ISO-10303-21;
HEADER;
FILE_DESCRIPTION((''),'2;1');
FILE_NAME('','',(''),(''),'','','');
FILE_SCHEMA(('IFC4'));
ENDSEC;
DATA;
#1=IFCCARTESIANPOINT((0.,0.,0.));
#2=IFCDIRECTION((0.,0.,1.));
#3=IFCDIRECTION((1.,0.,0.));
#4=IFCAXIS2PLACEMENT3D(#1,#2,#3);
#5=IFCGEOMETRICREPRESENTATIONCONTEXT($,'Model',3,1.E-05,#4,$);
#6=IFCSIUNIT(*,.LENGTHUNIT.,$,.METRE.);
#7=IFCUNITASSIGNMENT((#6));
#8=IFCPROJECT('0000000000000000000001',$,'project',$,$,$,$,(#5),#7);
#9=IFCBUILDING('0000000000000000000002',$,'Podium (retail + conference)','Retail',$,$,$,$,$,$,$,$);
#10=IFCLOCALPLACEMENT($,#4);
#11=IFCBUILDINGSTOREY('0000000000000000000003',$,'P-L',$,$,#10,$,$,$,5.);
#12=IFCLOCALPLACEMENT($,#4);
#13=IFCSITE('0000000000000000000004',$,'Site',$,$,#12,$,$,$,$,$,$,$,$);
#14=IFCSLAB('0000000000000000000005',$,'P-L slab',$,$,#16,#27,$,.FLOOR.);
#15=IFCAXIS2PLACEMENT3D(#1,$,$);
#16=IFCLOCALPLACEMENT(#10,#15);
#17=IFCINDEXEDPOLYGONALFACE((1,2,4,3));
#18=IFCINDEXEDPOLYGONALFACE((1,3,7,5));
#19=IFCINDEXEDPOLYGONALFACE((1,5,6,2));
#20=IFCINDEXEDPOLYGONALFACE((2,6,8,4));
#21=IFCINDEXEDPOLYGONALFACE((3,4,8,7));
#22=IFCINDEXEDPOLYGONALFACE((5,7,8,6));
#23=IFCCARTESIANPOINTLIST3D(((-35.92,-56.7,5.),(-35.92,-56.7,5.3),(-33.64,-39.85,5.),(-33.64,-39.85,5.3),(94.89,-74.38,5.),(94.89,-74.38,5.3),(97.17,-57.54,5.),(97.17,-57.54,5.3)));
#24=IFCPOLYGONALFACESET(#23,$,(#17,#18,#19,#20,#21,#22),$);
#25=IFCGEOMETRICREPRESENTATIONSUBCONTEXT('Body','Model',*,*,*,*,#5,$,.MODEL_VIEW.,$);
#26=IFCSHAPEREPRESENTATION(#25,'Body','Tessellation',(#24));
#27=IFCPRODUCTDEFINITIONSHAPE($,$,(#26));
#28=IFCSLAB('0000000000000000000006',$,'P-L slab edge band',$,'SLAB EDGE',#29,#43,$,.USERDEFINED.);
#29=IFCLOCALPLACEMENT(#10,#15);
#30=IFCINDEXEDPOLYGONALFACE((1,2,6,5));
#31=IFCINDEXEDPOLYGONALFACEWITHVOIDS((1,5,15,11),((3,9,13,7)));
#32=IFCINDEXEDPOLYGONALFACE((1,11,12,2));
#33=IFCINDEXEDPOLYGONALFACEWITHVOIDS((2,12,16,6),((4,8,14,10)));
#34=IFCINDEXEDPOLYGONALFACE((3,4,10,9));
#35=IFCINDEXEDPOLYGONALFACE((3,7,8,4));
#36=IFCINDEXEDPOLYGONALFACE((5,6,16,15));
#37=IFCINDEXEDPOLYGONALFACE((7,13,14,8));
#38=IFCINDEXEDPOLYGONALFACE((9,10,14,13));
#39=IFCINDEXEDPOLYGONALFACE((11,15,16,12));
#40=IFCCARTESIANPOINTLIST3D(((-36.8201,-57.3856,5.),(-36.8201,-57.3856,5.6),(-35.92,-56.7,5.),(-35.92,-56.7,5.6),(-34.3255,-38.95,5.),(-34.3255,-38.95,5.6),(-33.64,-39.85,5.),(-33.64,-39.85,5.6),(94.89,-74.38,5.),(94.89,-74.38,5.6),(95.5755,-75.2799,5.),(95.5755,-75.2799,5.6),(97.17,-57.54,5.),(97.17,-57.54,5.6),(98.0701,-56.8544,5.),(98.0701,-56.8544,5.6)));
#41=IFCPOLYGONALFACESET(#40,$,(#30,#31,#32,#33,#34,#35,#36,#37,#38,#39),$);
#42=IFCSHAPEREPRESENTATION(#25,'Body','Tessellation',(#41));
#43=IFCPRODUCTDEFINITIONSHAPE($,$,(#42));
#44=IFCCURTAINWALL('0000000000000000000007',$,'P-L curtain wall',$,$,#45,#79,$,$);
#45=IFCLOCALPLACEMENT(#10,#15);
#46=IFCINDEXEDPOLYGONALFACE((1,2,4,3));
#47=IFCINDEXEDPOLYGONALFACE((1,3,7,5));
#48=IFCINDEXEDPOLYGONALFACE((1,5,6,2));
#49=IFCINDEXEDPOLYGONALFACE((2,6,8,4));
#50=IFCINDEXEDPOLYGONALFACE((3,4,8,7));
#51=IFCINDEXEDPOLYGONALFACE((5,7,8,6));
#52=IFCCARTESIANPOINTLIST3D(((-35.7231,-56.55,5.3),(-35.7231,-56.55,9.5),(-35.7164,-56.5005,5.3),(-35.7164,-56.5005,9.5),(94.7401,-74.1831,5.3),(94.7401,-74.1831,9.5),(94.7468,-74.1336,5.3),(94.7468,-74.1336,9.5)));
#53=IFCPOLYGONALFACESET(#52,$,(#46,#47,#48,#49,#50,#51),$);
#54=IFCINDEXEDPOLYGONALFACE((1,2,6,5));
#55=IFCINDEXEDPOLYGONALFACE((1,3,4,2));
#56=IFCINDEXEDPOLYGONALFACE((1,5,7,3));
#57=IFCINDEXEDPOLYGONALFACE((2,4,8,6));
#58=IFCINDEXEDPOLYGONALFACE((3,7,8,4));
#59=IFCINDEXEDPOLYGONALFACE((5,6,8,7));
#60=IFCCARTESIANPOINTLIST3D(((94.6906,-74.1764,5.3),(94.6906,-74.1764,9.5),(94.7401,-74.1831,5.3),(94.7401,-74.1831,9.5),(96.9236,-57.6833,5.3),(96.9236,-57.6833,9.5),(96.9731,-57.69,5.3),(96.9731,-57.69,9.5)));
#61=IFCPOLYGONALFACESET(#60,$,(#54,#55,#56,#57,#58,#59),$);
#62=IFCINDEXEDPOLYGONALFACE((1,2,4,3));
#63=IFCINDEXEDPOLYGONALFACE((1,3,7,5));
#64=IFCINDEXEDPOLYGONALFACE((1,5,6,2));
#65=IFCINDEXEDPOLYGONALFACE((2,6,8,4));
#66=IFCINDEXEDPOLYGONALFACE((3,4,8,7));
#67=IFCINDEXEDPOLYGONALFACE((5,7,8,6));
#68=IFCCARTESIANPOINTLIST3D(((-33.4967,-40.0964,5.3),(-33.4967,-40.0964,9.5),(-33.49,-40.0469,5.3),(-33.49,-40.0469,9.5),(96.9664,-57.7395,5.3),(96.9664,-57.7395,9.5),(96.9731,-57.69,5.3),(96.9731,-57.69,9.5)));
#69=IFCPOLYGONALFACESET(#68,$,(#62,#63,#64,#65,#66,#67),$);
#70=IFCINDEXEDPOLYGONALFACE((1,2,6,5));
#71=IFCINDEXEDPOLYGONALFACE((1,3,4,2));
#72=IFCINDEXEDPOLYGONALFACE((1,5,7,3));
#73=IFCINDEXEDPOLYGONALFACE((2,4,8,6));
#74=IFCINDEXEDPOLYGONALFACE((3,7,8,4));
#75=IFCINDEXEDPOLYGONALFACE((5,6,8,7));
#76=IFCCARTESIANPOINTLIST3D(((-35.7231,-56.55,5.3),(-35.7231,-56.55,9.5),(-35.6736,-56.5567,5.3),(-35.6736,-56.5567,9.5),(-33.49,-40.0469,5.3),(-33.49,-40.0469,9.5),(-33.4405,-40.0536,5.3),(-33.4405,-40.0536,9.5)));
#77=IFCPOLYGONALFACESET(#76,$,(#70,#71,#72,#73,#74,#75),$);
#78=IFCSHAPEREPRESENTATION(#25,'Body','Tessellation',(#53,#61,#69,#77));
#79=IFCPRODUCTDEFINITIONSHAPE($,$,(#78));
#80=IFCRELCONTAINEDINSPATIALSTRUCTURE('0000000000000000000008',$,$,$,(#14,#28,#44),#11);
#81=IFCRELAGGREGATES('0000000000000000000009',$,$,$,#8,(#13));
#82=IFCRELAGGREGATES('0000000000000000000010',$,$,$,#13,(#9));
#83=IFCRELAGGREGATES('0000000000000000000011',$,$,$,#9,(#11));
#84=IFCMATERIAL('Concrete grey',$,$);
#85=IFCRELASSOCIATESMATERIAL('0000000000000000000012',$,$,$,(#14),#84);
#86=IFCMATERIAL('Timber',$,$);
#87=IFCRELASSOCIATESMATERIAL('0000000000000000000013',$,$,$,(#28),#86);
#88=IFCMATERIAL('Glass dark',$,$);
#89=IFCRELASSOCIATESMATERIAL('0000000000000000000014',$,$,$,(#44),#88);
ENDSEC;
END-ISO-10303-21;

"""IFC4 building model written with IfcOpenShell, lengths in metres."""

from ifc_helpers import new_model, si_unit, frame, origin_with_axes, place, context, subcontext, project, spatial, polyline, outline, extrude, material, element, save


model = new_model("IFC4")

# Units and contexts
model_context = context("Model", 3, precision=1e-05, world=origin_with_axes())
body_context = subcontext(model_context, "Body", "Model", "MODEL_VIEW")
ifc_project = project(units=[si_unit("LENGTHUNIT", "METRE")], contexts=[model_context])

# Site, building, storey
site_placement = place(None, origin_with_axes())
site = spatial("IfcSite", under=ifc_project, at=site_placement, Name="Site")
building = spatial("IfcBuilding", under=site, Name="Podium (retail + conference)", Description="Retail")
storey_placement = place(None, origin_with_axes())
storey = spatial("IfcBuildingStorey", under=building, at=storey_placement, Name="P-L", Elevation=5.0)

# Slabs
ifc_material_1 = material(Name="Concrete grey")
slab_1_placement = place(storey_placement, origin_with_axes())
element("IfcSlab", 1, at=slab_1_placement, inside=storey, material=ifc_material_1, Name="P-L slab", PredefinedType="FLOOR", context=body_context, shape_type="SweptSolid", body=[
    extrude(outline(polyline([(-35.92, -56.7), (94.89, -74.38), (97.17, -57.54), (-33.64, -39.85), (-35.92, -56.7)])), frame((0.0, 0.0, 5.0), z_axis=(0.0, 0.0, 1.0), x_axis=(1.0, 0.0, 0.0)), (0.0, 0.0, 1.0), 0.3),
])
ifc_material_2 = material(Name="Timber")
slab_2_placement = place(storey_placement, origin_with_axes())
element("IfcSlab", 2, at=slab_2_placement, inside=storey, material=ifc_material_2, Name="P-L slab edge band", ObjectType="SLAB EDGE", PredefinedType="USERDEFINED", context=body_context, shape_type="SweptSolid", body=[
    extrude(outline(polyline([(-36.8201, -57.3856), (95.5755, -75.2799), (98.0701, -56.8544), (-34.3255, -38.95), (-36.8201, -57.3856)]), holes=[polyline([(-35.92, -56.7), (94.89, -74.38), (97.17, -57.54), (-33.64, -39.85), (-35.92, -56.7)])]), frame((0.0, 0.0, 5.0), z_axis=(0.0, 0.0, 1.0), x_axis=(1.0, 0.0, 0.0)), (0.0, 0.0, 1.0), 0.6),
])

# Curtain wall
ifc_material_3 = material(Name="Glass dark")
curtain_wall_placement = place(storey_placement, origin_with_axes())
element("IfcCurtainWall", 3, at=curtain_wall_placement, inside=storey, material=ifc_material_3, Name="P-L curtain wall", context=body_context, shape_type="SweptSolid", body=[
    extrude(outline(polyline([(-35.7231, -56.55), (94.7401, -74.1831), (94.7468, -74.1336), (-35.7164, -56.5005), (-35.7231, -56.55)])), frame((0.0, 0.0, 5.3), z_axis=(0.0, 0.0, 1.0), x_axis=(1.0, 0.0, 0.0)), (0.0, 0.0, 1.0), 4.2),
    extrude(outline(polyline([(94.7401, -74.1831), (96.9731, -57.69), (96.9236, -57.6833), (94.6906, -74.1764), (94.7401, -74.1831)])), frame((0.0, 0.0, 5.3), z_axis=(0.0, 0.0, 1.0), x_axis=(1.0, 0.0, 0.0)), (0.0, 0.0, 1.0), 4.2),
    extrude(outline(polyline([(96.9731, -57.69), (-33.49, -40.0469), (-33.4967, -40.0964), (96.9664, -57.7395), (96.9731, -57.69)])), frame((0.0, 0.0, 5.3), z_axis=(0.0, 0.0, 1.0), x_axis=(1.0, 0.0, 0.0)), (0.0, 0.0, 1.0), 4.2),
    extrude(outline(polyline([(-33.49, -40.0469), (-35.7231, -56.55), (-35.6736, -56.5567), (-33.4405, -40.0536), (-33.49, -40.0469)])), frame((0.0, 0.0, 5.3), z_axis=(0.0, 0.0, 1.0), x_axis=(1.0, 0.0, 0.0)), (0.0, 0.0, 1.0), 4.2),
])

save(model, "model.ifc")
